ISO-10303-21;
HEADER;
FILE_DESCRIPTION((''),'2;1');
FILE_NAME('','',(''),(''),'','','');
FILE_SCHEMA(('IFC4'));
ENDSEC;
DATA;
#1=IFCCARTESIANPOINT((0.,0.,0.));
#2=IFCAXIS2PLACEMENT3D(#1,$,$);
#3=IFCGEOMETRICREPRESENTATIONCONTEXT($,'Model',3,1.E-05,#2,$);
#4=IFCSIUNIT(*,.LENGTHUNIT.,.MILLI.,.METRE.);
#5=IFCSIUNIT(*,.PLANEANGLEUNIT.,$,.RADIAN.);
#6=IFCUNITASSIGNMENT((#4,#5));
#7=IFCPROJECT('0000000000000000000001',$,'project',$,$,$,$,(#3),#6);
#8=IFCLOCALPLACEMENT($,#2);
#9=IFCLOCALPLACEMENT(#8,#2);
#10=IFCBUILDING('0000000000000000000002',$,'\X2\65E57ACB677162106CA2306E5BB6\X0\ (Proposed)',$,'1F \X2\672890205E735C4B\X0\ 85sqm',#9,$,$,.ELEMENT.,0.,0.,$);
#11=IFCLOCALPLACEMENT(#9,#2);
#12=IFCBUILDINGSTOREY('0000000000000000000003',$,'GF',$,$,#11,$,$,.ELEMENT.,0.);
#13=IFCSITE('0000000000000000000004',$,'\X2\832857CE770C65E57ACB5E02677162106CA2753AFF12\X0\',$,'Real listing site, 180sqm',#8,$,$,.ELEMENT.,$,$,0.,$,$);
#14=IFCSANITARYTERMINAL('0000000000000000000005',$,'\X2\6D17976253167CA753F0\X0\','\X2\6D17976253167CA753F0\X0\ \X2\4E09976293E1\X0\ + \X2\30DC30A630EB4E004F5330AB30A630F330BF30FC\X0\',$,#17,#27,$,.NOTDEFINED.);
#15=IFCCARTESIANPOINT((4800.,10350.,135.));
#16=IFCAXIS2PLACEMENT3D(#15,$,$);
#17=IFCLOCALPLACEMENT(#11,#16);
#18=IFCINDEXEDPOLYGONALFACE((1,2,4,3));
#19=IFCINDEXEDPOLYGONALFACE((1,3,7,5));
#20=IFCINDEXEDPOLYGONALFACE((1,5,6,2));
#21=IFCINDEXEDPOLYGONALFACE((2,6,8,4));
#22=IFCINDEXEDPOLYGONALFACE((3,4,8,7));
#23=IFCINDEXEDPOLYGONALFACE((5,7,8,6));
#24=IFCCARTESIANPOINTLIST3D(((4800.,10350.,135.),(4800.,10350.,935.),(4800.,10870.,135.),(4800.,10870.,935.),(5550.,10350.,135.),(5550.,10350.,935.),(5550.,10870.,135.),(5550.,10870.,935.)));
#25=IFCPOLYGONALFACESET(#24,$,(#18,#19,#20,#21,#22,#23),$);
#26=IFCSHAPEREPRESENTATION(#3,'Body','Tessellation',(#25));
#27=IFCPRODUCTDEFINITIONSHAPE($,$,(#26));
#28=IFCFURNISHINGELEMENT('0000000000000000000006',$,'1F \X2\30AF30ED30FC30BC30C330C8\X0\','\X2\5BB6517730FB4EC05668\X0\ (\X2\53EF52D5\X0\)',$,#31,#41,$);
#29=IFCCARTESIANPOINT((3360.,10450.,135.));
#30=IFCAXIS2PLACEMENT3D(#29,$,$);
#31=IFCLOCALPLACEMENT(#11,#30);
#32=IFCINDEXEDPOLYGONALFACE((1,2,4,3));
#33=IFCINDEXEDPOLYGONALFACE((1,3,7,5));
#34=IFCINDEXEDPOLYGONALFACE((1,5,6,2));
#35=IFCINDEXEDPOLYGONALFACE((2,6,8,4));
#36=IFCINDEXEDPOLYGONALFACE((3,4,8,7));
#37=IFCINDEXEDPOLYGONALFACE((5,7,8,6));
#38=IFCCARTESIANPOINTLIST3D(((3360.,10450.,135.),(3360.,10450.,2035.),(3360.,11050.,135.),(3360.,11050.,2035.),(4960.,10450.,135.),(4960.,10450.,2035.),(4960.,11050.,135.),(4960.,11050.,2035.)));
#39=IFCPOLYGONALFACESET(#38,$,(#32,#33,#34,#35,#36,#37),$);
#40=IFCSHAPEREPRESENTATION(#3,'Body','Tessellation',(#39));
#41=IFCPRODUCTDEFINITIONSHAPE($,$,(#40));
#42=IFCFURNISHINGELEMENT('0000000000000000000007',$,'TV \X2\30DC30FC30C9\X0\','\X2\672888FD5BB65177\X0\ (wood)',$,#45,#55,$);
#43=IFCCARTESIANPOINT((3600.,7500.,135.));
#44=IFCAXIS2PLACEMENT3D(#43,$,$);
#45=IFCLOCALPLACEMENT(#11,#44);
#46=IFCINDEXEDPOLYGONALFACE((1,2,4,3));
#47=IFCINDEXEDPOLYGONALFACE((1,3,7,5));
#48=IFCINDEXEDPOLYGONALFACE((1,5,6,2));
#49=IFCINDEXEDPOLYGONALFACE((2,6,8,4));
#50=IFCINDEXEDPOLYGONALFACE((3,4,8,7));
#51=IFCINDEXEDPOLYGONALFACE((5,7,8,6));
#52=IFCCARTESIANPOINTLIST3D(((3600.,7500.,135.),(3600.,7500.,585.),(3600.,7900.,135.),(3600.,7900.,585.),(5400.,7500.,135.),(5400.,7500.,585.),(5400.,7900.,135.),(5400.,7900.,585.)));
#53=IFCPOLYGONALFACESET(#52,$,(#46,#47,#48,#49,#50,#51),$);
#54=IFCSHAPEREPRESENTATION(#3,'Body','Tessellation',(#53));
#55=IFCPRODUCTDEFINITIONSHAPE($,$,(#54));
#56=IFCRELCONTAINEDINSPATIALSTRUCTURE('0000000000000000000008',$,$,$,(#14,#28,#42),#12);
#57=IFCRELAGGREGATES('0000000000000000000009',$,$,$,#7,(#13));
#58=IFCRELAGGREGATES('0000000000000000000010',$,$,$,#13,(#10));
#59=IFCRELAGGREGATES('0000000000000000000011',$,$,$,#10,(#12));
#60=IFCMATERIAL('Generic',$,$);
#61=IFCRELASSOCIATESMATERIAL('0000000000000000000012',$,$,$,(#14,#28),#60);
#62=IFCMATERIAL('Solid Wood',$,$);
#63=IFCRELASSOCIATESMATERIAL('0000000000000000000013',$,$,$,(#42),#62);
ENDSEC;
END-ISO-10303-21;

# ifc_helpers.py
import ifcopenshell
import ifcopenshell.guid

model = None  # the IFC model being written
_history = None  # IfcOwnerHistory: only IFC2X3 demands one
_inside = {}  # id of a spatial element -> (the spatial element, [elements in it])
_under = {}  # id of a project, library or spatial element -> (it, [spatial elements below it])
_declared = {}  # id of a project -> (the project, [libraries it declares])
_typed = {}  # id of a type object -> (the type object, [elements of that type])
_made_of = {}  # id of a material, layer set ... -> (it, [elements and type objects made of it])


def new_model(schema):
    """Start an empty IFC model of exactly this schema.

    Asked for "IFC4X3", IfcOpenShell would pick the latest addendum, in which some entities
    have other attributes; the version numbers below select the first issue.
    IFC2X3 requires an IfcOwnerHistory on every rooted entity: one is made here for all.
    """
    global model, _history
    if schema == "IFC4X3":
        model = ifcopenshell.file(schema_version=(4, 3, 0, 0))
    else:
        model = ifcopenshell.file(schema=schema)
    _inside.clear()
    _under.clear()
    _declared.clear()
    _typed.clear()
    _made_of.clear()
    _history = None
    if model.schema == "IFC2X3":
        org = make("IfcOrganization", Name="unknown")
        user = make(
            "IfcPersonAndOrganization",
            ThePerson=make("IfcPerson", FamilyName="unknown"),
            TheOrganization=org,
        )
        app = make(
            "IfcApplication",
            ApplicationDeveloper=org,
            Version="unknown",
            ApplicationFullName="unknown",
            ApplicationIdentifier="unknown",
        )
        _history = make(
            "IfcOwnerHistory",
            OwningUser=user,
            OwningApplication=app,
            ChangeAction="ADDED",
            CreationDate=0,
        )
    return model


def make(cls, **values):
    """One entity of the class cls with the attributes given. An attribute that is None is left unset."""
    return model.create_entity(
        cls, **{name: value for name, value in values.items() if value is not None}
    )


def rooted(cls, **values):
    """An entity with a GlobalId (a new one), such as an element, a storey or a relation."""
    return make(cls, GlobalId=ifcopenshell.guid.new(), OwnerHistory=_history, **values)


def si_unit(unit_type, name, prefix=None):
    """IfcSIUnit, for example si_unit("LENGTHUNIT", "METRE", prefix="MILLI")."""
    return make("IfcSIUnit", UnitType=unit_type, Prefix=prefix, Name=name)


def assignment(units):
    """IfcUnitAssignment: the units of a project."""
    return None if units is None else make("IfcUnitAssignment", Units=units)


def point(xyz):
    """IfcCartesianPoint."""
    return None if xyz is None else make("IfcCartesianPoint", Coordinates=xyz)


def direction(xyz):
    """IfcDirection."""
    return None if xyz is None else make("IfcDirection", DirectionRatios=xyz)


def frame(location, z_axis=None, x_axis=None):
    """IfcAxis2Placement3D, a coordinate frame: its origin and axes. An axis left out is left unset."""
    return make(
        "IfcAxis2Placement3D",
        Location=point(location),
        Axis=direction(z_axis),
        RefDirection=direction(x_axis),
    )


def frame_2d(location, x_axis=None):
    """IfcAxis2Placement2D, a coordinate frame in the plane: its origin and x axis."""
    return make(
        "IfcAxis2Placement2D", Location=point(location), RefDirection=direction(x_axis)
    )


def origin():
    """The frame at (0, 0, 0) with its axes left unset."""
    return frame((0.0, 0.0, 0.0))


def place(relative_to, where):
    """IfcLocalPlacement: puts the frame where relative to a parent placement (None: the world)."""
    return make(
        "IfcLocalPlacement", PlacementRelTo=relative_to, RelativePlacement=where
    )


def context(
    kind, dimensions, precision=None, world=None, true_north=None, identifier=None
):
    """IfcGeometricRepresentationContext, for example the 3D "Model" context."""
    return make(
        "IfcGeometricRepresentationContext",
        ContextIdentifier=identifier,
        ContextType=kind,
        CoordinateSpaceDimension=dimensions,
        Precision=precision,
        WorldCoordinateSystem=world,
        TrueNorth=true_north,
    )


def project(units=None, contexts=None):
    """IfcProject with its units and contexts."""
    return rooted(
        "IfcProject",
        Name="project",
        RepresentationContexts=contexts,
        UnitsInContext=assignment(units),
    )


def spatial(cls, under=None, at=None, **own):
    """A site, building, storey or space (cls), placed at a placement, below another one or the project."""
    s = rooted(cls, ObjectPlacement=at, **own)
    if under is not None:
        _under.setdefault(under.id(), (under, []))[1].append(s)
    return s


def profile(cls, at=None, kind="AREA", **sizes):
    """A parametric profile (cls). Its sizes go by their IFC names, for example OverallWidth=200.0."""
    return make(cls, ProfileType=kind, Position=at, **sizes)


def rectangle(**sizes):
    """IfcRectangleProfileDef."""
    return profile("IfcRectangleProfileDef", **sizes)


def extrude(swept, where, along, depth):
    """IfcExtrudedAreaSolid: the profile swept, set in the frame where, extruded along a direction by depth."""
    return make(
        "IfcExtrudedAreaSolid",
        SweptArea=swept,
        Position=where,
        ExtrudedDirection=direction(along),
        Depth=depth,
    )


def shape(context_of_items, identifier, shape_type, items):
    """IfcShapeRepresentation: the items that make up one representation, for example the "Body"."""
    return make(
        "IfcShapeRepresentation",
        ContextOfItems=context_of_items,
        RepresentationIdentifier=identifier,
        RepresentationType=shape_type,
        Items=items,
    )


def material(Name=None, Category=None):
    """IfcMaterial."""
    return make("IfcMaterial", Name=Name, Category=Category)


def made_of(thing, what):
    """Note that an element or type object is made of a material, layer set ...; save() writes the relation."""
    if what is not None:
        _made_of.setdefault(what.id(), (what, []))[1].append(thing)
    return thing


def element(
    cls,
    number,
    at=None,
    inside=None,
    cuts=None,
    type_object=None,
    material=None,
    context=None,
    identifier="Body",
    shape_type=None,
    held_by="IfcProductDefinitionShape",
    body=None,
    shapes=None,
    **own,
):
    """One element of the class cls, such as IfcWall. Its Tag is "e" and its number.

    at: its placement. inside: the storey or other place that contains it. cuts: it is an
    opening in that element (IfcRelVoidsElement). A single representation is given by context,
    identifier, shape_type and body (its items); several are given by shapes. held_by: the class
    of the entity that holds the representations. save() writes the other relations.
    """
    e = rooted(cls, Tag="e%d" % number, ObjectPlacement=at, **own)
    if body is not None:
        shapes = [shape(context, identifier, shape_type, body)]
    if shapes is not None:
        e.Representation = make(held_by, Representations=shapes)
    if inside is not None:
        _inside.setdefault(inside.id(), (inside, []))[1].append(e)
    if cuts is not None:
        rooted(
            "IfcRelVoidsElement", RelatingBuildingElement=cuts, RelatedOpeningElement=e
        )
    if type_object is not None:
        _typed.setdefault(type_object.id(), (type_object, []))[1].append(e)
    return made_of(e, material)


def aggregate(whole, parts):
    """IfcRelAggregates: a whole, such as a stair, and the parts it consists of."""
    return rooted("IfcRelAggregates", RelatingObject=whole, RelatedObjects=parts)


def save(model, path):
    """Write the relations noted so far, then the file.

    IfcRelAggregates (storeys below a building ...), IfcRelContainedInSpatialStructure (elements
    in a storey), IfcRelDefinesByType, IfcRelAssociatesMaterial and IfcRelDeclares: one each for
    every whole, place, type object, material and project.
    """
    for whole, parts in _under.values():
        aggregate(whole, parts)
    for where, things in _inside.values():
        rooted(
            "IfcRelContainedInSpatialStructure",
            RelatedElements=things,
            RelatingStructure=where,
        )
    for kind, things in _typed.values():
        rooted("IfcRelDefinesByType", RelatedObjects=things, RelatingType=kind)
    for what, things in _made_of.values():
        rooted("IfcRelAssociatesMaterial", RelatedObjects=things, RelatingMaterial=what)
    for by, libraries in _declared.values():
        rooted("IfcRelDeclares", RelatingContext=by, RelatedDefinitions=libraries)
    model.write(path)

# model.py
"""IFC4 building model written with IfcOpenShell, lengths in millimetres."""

from ifc_helpers import new_model, si_unit, frame, frame_2d, origin, place, context, project, spatial, rectangle, extrude, material, element, save


model = new_model("IFC4")

# Units and contexts
model_context = context("Model", 3, precision=1e-05, world=origin())
ifc_project = project(units=[si_unit("LENGTHUNIT", "METRE", prefix="MILLI"), si_unit("PLANEANGLEUNIT", "RADIAN")], contexts=[model_context])

# Site, building, storey
site_placement = place(None, origin())
site = spatial("IfcSite", under=ifc_project, at=site_placement, Name="茨城県日立市東成沢町２", ObjectType="Real listing site, 180sqm", CompositionType="ELEMENT", RefElevation=0.0)
building_placement = place(site_placement, origin())
building = spatial("IfcBuilding", under=site, at=building_placement, Name="日立東成沢の家 (Proposed)", ObjectType="1F 木造平屋 85sqm", CompositionType="ELEMENT", ElevationOfRefHeight=0.0, ElevationOfTerrain=0.0)
storey_placement = place(building_placement, origin())
storey = spatial("IfcBuildingStorey", under=building, at=storey_placement, Name="GF", CompositionType="ELEMENT", Elevation=0.0)

# Shared definitions
ifc_material_1 = material(Name="Solid Wood")

# Shared definitions
ifc_material_2 = material(Name="Generic")

# Sanitary terminal
sanitary_terminal_1_placement = place(storey_placement, frame((4800.0, 10350.0, 135.0)))
element("IfcSanitaryTerminal", 1, at=sanitary_terminal_1_placement, inside=storey, material=ifc_material_2, Name="洗面化粧台", Description="洗面化粧台 三面鏡 + ボウル一体カウンター", PredefinedType="NOTDEFINED", context=model_context, shape_type="SweptSolid", body=[
    extrude(rectangle(XDim=750.0, YDim=520.0, at=frame_2d((375.0, 260.0))), frame((4800.0, 10350.0, 135.0)), (0.0, 0.0, 1.0), 800.0),
])

# Furnishing elements
furnishing_1_placement = place(storey_placement, frame((3360.0, 10450.0, 135.0)))
element("IfcFurnishingElement", 2, at=furnishing_1_placement, inside=storey, material=ifc_material_2, Name="1F クローゼット", Description="家具・什器 (可動)", context=model_context, shape_type="SweptSolid", body=[
    extrude(rectangle(XDim=1600.0, YDim=600.0, at=frame_2d((800.0, 300.0))), frame((3360.0, 10450.0, 135.0)), (0.0, 0.0, 1.0), 1900.0),
])
furnishing_2_placement = place(storey_placement, frame((3600.0, 7500.0, 135.0)))
element("IfcFurnishingElement", 3, at=furnishing_2_placement, inside=storey, material=ifc_material_1, Name="TV ボード", Description="木製家具 (wood)", context=model_context, shape_type="SweptSolid", body=[
    extrude(rectangle(XDim=1800.0, YDim=400.0, at=frame_2d((900.0, 200.0))), frame((3600.0, 7500.0, 135.0)), (0.0, 0.0, 1.0), 450.0),
])

save(model, "model.ifc")
